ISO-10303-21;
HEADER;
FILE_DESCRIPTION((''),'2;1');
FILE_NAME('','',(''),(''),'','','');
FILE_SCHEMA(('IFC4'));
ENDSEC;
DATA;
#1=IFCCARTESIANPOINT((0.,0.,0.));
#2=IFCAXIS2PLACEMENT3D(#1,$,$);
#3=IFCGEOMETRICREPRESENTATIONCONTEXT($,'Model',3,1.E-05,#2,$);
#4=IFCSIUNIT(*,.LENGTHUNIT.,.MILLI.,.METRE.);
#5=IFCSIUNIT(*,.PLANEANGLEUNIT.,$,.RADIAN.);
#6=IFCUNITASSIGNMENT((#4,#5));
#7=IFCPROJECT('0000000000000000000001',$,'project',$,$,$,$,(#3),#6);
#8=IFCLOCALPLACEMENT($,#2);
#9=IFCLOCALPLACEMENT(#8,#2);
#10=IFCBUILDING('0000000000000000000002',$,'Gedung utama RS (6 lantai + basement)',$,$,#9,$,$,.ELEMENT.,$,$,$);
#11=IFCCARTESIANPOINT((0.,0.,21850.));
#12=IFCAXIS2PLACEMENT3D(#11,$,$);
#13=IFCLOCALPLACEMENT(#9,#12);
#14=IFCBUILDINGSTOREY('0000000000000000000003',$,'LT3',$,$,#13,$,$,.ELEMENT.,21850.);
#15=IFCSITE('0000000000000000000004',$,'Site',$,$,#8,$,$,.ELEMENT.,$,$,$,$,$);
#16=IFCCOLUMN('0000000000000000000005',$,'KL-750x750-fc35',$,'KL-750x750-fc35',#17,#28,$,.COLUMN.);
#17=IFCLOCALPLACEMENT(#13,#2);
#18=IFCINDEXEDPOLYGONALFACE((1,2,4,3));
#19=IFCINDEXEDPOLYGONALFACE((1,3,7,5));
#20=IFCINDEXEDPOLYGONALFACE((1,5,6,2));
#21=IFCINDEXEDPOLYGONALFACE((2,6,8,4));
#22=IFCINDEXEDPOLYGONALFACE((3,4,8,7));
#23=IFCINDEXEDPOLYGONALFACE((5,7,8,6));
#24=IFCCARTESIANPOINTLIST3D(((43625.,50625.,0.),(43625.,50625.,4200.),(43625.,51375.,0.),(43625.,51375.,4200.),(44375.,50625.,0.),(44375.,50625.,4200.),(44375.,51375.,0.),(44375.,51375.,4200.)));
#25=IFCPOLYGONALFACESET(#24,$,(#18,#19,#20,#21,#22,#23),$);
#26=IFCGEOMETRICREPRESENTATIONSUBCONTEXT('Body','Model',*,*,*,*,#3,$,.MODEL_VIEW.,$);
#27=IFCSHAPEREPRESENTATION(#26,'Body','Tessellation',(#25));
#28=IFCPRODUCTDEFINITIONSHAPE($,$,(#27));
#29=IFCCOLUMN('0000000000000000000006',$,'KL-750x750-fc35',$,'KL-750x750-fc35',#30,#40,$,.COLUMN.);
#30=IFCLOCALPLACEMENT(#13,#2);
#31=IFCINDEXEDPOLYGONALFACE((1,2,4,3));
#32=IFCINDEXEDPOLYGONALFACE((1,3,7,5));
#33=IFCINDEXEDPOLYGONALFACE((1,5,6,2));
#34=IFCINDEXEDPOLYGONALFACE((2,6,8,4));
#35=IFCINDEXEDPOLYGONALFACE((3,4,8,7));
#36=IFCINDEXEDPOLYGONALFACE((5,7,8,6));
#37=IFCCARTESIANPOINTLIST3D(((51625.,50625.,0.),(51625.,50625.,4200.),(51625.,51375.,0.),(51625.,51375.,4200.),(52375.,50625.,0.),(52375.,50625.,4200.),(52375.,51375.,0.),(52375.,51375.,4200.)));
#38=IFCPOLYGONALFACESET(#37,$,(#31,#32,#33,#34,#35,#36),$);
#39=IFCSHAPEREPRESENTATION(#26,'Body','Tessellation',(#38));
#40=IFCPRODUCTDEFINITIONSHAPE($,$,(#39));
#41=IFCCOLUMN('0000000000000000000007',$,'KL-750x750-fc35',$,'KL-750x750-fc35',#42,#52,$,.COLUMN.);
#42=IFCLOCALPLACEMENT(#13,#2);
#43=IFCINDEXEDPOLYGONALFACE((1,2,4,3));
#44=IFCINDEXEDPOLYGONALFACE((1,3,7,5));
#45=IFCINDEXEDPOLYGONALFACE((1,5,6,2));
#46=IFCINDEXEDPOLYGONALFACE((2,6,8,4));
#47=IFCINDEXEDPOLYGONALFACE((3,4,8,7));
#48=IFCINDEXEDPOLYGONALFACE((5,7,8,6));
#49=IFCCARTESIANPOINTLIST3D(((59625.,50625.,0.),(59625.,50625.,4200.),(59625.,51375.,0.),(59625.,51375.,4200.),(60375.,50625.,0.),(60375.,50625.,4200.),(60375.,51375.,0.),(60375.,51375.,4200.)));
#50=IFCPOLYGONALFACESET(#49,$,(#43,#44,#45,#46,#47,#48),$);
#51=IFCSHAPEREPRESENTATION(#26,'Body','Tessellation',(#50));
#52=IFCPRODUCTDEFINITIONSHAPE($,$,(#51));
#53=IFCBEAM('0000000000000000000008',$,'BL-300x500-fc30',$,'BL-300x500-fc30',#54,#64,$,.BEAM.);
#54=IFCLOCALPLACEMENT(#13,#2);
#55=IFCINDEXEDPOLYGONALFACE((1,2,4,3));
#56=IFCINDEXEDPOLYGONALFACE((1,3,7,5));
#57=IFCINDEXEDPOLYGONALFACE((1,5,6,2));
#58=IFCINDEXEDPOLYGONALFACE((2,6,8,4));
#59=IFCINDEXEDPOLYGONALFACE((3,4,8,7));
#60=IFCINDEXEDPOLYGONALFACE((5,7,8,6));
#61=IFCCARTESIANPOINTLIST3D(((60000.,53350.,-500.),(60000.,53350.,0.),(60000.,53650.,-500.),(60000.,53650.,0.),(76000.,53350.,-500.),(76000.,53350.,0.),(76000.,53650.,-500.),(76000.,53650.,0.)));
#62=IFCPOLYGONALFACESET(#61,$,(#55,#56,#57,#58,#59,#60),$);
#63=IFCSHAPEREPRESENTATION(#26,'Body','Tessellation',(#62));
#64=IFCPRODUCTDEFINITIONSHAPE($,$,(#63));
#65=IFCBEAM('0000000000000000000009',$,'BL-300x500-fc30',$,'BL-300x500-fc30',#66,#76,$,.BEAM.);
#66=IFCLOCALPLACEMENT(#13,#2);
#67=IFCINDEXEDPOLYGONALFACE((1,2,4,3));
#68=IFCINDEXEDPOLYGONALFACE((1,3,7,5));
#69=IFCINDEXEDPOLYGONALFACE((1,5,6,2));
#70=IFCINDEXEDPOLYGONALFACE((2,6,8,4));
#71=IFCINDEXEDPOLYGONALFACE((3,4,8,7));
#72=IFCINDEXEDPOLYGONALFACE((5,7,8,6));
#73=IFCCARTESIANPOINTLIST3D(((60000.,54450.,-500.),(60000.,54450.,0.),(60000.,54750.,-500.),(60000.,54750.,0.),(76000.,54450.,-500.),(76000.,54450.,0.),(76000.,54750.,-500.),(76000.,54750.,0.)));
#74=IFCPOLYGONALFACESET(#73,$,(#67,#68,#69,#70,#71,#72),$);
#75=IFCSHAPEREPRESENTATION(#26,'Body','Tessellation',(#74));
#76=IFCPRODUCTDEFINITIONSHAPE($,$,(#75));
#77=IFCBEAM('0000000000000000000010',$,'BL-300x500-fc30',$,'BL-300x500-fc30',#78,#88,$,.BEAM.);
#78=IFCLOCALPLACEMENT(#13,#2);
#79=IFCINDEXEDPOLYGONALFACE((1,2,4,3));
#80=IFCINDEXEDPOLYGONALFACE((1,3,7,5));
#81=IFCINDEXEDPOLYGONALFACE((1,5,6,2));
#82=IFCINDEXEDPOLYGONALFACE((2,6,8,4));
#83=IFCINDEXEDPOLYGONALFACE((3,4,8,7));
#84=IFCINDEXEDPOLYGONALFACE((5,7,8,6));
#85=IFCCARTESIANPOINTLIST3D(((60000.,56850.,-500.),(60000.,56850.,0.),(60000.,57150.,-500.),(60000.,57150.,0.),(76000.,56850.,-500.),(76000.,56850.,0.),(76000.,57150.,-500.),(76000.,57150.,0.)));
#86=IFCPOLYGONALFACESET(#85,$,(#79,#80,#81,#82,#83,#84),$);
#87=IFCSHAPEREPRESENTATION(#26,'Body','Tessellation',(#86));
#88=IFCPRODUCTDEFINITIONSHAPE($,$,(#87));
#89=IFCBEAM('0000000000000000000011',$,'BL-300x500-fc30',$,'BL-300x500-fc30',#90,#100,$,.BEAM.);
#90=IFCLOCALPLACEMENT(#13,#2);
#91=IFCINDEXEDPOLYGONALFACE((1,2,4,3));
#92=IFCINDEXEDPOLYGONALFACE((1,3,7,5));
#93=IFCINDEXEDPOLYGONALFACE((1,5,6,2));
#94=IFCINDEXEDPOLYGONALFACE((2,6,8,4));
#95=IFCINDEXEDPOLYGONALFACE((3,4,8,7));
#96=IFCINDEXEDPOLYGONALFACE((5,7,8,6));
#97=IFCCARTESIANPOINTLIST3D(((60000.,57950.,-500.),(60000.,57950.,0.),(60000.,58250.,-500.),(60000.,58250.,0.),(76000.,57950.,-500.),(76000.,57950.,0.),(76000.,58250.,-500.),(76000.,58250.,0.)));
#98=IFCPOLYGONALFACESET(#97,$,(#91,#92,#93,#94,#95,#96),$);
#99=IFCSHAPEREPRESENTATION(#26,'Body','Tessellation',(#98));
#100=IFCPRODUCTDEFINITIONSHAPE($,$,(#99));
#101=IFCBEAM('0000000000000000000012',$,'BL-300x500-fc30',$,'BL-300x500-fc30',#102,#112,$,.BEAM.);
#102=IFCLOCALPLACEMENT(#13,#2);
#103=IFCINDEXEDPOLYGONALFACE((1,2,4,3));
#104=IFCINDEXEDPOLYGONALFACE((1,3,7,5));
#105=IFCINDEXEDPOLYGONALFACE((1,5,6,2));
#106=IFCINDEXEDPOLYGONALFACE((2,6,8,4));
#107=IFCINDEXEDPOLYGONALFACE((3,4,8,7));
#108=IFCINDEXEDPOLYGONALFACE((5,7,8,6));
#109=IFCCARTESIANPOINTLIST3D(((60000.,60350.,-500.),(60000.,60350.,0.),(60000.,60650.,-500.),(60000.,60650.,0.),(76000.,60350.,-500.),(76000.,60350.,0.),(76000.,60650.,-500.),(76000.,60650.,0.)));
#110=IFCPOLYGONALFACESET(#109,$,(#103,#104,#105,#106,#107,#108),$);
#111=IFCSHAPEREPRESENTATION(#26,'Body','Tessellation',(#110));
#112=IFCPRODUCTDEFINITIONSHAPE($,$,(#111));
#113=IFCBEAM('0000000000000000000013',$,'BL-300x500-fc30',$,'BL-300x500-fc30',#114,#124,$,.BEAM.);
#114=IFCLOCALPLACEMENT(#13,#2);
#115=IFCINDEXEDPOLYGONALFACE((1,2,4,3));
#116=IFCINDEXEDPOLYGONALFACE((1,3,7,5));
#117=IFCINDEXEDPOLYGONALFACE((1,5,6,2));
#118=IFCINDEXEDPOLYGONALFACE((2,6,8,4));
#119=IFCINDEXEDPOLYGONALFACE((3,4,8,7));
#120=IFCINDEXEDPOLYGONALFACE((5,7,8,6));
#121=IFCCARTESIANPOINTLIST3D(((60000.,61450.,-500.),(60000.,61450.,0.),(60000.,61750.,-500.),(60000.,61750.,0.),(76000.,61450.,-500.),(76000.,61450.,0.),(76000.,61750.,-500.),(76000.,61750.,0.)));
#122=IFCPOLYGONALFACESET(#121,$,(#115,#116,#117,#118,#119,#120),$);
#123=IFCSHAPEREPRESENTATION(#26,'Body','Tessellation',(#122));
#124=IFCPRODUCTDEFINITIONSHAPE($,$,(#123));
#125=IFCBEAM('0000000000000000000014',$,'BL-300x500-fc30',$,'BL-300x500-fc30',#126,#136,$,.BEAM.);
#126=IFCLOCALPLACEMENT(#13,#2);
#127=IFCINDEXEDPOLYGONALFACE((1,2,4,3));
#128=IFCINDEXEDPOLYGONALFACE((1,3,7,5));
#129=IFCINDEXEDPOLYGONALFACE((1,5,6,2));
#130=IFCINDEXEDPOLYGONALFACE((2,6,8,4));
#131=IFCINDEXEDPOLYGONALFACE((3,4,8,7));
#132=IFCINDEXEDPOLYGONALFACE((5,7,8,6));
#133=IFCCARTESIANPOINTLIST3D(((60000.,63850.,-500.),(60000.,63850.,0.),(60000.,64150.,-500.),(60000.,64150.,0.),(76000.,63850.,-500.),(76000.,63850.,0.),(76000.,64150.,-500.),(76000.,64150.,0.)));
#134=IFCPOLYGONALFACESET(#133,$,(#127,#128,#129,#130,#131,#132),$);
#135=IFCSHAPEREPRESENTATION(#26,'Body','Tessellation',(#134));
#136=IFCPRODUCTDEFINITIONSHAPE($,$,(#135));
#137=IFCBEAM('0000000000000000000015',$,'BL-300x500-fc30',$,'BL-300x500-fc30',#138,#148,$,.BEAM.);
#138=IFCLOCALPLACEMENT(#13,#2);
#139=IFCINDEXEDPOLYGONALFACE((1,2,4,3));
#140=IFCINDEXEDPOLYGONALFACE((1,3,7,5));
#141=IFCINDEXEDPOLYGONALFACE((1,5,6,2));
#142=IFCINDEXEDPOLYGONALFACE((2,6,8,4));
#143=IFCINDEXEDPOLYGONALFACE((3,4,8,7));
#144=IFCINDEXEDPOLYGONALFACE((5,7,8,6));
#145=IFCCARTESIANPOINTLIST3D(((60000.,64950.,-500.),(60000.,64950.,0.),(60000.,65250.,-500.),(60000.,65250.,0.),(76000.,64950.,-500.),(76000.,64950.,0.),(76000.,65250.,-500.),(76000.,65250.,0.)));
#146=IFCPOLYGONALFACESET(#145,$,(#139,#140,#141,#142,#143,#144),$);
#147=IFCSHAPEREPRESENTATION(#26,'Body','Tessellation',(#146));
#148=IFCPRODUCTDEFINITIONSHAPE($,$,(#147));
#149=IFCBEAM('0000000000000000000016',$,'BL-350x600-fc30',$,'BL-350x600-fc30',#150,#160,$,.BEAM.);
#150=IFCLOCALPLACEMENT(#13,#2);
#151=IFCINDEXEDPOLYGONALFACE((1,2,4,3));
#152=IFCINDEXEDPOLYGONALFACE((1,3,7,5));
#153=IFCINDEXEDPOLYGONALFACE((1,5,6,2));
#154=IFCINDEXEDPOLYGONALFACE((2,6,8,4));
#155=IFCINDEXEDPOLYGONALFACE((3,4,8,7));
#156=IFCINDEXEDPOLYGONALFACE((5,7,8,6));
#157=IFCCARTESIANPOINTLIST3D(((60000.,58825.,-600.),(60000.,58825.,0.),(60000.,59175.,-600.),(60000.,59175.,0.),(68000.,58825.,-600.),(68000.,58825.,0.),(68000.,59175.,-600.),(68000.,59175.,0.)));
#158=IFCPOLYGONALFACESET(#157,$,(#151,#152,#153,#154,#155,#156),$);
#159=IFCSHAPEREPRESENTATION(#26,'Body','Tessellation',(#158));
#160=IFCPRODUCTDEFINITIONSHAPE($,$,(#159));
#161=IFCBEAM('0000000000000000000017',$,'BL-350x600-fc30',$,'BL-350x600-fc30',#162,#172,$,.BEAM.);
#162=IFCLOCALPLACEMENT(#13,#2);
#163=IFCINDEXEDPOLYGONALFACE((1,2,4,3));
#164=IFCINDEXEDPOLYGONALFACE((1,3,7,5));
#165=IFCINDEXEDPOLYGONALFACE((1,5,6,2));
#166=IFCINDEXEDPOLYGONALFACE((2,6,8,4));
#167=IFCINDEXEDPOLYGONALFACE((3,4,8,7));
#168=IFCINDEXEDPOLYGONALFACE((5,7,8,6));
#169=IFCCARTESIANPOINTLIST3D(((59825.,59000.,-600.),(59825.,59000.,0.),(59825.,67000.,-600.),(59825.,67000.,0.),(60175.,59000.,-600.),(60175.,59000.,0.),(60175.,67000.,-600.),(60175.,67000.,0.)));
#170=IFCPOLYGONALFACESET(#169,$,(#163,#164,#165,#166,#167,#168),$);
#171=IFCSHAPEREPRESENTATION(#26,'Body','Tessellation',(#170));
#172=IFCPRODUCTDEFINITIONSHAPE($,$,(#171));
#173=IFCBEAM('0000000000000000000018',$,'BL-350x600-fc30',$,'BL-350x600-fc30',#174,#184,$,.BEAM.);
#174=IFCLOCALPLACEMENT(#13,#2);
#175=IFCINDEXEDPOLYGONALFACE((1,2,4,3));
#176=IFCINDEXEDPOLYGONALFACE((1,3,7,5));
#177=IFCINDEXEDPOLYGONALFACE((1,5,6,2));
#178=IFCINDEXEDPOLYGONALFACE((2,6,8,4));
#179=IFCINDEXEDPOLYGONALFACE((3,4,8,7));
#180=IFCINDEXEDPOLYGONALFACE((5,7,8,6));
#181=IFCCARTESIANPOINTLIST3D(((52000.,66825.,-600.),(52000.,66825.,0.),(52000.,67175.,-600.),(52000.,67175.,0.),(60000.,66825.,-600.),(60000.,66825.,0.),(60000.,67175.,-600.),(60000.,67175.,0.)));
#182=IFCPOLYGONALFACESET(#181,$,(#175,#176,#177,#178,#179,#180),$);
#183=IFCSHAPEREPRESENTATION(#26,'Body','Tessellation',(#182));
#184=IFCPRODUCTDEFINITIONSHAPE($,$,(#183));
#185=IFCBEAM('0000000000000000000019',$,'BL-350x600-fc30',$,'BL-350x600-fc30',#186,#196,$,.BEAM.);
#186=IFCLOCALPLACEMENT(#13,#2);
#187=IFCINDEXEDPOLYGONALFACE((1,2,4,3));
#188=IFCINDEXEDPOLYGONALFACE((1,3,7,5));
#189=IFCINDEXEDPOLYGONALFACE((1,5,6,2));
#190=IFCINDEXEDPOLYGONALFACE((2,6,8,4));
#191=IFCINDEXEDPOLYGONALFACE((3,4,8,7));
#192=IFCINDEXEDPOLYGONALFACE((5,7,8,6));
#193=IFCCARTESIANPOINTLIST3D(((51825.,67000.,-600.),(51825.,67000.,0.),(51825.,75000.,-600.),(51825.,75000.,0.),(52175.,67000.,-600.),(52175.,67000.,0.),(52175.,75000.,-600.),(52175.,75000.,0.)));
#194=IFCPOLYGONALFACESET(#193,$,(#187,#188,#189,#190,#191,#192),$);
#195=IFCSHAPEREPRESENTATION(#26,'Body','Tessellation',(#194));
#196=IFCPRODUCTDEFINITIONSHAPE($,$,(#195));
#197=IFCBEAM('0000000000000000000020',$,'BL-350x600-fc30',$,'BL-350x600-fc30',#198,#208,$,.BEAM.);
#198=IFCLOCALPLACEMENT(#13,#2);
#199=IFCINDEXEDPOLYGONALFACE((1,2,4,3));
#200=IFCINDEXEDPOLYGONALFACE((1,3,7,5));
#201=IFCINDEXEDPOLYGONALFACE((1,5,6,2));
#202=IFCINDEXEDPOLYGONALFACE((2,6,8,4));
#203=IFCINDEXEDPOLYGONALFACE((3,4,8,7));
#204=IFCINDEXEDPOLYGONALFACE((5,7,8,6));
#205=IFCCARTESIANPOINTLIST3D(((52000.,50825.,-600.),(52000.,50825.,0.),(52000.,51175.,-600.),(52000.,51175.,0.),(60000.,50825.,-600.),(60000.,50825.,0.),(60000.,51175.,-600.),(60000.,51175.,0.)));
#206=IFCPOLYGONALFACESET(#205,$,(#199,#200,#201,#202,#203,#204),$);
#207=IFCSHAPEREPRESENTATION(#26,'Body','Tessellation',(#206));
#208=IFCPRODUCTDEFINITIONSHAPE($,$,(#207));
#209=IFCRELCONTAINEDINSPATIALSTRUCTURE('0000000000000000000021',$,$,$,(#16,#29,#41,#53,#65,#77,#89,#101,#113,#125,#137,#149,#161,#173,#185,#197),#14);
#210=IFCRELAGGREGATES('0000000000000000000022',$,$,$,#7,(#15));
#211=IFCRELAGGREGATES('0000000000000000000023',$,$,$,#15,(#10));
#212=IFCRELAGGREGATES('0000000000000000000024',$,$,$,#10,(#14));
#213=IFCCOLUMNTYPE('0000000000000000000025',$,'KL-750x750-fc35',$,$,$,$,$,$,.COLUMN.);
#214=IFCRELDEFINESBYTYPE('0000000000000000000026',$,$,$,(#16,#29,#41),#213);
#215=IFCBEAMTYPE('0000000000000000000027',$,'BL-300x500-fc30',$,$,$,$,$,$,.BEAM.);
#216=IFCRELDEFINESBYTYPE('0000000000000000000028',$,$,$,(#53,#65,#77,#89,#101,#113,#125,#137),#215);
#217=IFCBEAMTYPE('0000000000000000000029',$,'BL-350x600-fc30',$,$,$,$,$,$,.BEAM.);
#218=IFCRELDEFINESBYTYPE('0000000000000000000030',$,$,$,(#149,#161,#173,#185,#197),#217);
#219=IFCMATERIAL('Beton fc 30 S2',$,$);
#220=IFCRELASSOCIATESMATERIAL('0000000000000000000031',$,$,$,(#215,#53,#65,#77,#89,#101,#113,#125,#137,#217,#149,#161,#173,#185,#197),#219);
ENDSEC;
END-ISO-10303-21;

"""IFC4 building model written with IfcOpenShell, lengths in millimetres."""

from ifc_helpers import new_model, si_unit, frame, origin, origin_2d, place, context, subcontext, project, spatial, rectangle, extrude, material, material_profile, profile_set, profile_usage, type_object, element, save


model = new_model("IFC4")

# Units and contexts
model_context = context("Model", 3, precision=1e-05, world=origin())
body_context = subcontext(model_context, "Body", "Model", "MODEL_VIEW")
ifc_project = project(units=[si_unit("LENGTHUNIT", "METRE", prefix="MILLI"), si_unit("PLANEANGLEUNIT", "RADIAN")], contexts=[model_context])

# Site, building, storey
site_placement = place(None, origin())
site = spatial("IfcSite", under=ifc_project, at=site_placement, Name="Site", CompositionType="ELEMENT")
building_placement = place(site_placement, origin())
building = spatial("IfcBuilding", under=site, at=building_placement, Name="Gedung utama RS (6 lantai + basement)", CompositionType="ELEMENT")
storey_placement = place(building_placement, frame((0.0, 0.0, 21850.0)))
storey = spatial("IfcBuildingStorey", under=building, at=storey_placement, Name="LT3", CompositionType="ELEMENT", Elevation=21850.0)

# Columns
ifc_material_profile_1 = material_profile(None, rectangle(XDim=750.0, YDim=750.0, at=origin_2d()), Name="KL-750x750-fc35")
ifc_profile_set_1 = profile_set([ifc_material_profile_1], Name="KL-750x750-fc35")
ifc_profile_usage_1 = profile_usage(ifc_profile_set_1, cardinal=5)
column_type = type_object("IfcColumnType", Name="KL-750x750-fc35", PredefinedType="COLUMN", material=ifc_profile_set_1)
for number, where, z_axis, x_axis, name in (
    (1, (44000.0, 51000.0, 0.0), (0.0, 0.0, 1.0), (1.0, 0.0, 0.0), "KL-750x750-fc35"),
    (2, (52000.0, 51000.0, 0.0), (0.0, 0.0, 1.0), (1.0, 0.0, 0.0), "KL-750x750-fc35"),
    (3, (60000.0, 51000.0, 0.0), (0.0, 0.0, 1.0), (1.0, 0.0, 0.0), "KL-750x750-fc35"),
):
    element("IfcColumn", number, at=place(storey_placement, frame(where, z_axis=z_axis, x_axis=x_axis)), inside=storey, type_object=column_type, material=ifc_profile_usage_1, Name=name, ObjectType="KL-750x750-fc35", PredefinedType="COLUMN", context=body_context, shape_type="SweptSolid", body=[
        extrude(rectangle(XDim=750.0, YDim=750.0, at=origin_2d()), origin(), (0.0, 0.0, 1.0), 4200.0),
    ])

# Beams
ifc_material = material(Name="Beton fc 30 S2")
ifc_material_profile_2 = material_profile(ifc_material, rectangle(XDim=300.0, YDim=500.0, at=origin_2d()), Name="BL-300x500-fc30")
ifc_profile_set_2 = profile_set([ifc_material_profile_2], Name="BL-300x500-fc30")
ifc_profile_usage_2 = profile_usage(ifc_profile_set_2, cardinal=8)
beam_type_1 = type_object("IfcBeamType", Name="BL-300x500-fc30", PredefinedType="BEAM", material=ifc_profile_set_2)
for number, where, name in (
    (4, (60000.0, 53500.0, -250.0), "BL-300x500-fc30"),
    (5, (60000.0, 54600.0, -250.0), "BL-300x500-fc30"),
    (6, (60000.0, 57000.0, -250.0), "BL-300x500-fc30"),
    (7, (60000.0, 58100.0, -250.0), "BL-300x500-fc30"),
    (8, (60000.0, 60500.0, -250.0), "BL-300x500-fc30"),
    (9, (60000.0, 61600.0, -250.0), "BL-300x500-fc30"),
    (10, (60000.0, 64000.0, -250.0), "BL-300x500-fc30"),
    (11, (60000.0, 65100.0, -250.0), "BL-300x500-fc30"),
):
    element("IfcBeam", number, at=place(storey_placement, frame(where)), inside=storey, type_object=beam_type_1, material=ifc_profile_usage_2, Name=name, ObjectType="BL-300x500-fc30", PredefinedType="BEAM", context=body_context, shape_type="SweptSolid", body=[
        extrude(rectangle(XDim=300.0, YDim=500.0, at=origin_2d()), frame((0.0, 0.0, 0.0), z_axis=(1.0, 0.0, 0.0), x_axis=(0.0, 1.0, 0.0)), (0.0, 0.0, 1.0), 16000.0),
    ])
ifc_material_profile_3 = material_profile(ifc_material, rectangle(XDim=350.0, YDim=600.0, at=origin_2d()), Name="BL-350x600-fc30")
ifc_profile_set_3 = profile_set([ifc_material_profile_3], Name="BL-350x600-fc30")
ifc_profile_usage_3 = profile_usage(ifc_profile_set_3, cardinal=8)
beam_type_2 = type_object("IfcBeamType", Name="BL-350x600-fc30", PredefinedType="BEAM", material=ifc_profile_set_3)
beam_1_placement = place(storey_placement, frame((60000.0, 59000.0, -300.0)))
element("IfcBeam", 12, at=beam_1_placement, inside=storey, type_object=beam_type_2, material=ifc_profile_usage_3, Name="BL-350x600-fc30", ObjectType="BL-350x600-fc30", PredefinedType="BEAM", context=body_context, shape_type="SweptSolid", body=[
    extrude(rectangle(XDim=350.0, YDim=600.0, at=origin_2d()), frame((0.0, 0.0, 0.0), z_axis=(1.0, 0.0, 0.0), x_axis=(0.0, 1.0, 0.0)), (0.0, 0.0, 1.0), 8000.0),
])
beam_2_placement = place(storey_placement, frame((60000.0, 59000.0, -300.0)))
element("IfcBeam", 13, at=beam_2_placement, inside=storey, type_object=beam_type_2, material=ifc_profile_usage_3, Name="BL-350x600-fc30", ObjectType="BL-350x600-fc30", PredefinedType="BEAM", context=body_context, shape_type="SweptSolid", body=[
    extrude(rectangle(XDim=350.0, YDim=600.0, at=origin_2d()), frame((0.0, 0.0, 0.0), z_axis=(0.0, 1.0, 0.0), x_axis=(-1.0, 0.0, 0.0)), (0.0, 0.0, 1.0), 8000.0),
])
beam_3_placement = place(storey_placement, frame((52000.0, 67000.0, -300.0)))
element("IfcBeam", 14, at=beam_3_placement, inside=storey, type_object=beam_type_2, material=ifc_profile_usage_3, Name="BL-350x600-fc30", ObjectType="BL-350x600-fc30", PredefinedType="BEAM", context=body_context, shape_type="SweptSolid", body=[
    extrude(rectangle(XDim=350.0, YDim=600.0, at=origin_2d()), frame((0.0, 0.0, 0.0), z_axis=(1.0, 0.0, 0.0), x_axis=(0.0, 1.0, 0.0)), (0.0, 0.0, 1.0), 8000.0),
])
beam_4_placement = place(storey_placement, frame((52000.0, 67000.0, -300.0)))
element("IfcBeam", 15, at=beam_4_placement, inside=storey, type_object=beam_type_2, material=ifc_profile_usage_3, Name="BL-350x600-fc30", ObjectType="BL-350x600-fc30", PredefinedType="BEAM", context=body_context, shape_type="SweptSolid", body=[
    extrude(rectangle(XDim=350.0, YDim=600.0, at=origin_2d()), frame((0.0, 0.0, 0.0), z_axis=(0.0, 1.0, 0.0), x_axis=(-1.0, 0.0, 0.0)), (0.0, 0.0, 1.0), 8000.0),
])
beam_5_placement = place(storey_placement, frame((52000.0, 51000.0, -300.0)))
element("IfcBeam", 16, at=beam_5_placement, inside=storey, type_object=beam_type_2, material=ifc_profile_usage_3, Name="BL-350x600-fc30", ObjectType="BL-350x600-fc30", PredefinedType="BEAM", context=body_context, shape_type="SweptSolid", body=[
    extrude(rectangle(XDim=350.0, YDim=600.0, at=origin_2d()), frame((0.0, 0.0, 0.0), z_axis=(1.0, 0.0, 0.0), x_axis=(0.0, 1.0, 0.0)), (0.0, 0.0, 1.0), 8000.0),
])

save(model, "model.ifc")
